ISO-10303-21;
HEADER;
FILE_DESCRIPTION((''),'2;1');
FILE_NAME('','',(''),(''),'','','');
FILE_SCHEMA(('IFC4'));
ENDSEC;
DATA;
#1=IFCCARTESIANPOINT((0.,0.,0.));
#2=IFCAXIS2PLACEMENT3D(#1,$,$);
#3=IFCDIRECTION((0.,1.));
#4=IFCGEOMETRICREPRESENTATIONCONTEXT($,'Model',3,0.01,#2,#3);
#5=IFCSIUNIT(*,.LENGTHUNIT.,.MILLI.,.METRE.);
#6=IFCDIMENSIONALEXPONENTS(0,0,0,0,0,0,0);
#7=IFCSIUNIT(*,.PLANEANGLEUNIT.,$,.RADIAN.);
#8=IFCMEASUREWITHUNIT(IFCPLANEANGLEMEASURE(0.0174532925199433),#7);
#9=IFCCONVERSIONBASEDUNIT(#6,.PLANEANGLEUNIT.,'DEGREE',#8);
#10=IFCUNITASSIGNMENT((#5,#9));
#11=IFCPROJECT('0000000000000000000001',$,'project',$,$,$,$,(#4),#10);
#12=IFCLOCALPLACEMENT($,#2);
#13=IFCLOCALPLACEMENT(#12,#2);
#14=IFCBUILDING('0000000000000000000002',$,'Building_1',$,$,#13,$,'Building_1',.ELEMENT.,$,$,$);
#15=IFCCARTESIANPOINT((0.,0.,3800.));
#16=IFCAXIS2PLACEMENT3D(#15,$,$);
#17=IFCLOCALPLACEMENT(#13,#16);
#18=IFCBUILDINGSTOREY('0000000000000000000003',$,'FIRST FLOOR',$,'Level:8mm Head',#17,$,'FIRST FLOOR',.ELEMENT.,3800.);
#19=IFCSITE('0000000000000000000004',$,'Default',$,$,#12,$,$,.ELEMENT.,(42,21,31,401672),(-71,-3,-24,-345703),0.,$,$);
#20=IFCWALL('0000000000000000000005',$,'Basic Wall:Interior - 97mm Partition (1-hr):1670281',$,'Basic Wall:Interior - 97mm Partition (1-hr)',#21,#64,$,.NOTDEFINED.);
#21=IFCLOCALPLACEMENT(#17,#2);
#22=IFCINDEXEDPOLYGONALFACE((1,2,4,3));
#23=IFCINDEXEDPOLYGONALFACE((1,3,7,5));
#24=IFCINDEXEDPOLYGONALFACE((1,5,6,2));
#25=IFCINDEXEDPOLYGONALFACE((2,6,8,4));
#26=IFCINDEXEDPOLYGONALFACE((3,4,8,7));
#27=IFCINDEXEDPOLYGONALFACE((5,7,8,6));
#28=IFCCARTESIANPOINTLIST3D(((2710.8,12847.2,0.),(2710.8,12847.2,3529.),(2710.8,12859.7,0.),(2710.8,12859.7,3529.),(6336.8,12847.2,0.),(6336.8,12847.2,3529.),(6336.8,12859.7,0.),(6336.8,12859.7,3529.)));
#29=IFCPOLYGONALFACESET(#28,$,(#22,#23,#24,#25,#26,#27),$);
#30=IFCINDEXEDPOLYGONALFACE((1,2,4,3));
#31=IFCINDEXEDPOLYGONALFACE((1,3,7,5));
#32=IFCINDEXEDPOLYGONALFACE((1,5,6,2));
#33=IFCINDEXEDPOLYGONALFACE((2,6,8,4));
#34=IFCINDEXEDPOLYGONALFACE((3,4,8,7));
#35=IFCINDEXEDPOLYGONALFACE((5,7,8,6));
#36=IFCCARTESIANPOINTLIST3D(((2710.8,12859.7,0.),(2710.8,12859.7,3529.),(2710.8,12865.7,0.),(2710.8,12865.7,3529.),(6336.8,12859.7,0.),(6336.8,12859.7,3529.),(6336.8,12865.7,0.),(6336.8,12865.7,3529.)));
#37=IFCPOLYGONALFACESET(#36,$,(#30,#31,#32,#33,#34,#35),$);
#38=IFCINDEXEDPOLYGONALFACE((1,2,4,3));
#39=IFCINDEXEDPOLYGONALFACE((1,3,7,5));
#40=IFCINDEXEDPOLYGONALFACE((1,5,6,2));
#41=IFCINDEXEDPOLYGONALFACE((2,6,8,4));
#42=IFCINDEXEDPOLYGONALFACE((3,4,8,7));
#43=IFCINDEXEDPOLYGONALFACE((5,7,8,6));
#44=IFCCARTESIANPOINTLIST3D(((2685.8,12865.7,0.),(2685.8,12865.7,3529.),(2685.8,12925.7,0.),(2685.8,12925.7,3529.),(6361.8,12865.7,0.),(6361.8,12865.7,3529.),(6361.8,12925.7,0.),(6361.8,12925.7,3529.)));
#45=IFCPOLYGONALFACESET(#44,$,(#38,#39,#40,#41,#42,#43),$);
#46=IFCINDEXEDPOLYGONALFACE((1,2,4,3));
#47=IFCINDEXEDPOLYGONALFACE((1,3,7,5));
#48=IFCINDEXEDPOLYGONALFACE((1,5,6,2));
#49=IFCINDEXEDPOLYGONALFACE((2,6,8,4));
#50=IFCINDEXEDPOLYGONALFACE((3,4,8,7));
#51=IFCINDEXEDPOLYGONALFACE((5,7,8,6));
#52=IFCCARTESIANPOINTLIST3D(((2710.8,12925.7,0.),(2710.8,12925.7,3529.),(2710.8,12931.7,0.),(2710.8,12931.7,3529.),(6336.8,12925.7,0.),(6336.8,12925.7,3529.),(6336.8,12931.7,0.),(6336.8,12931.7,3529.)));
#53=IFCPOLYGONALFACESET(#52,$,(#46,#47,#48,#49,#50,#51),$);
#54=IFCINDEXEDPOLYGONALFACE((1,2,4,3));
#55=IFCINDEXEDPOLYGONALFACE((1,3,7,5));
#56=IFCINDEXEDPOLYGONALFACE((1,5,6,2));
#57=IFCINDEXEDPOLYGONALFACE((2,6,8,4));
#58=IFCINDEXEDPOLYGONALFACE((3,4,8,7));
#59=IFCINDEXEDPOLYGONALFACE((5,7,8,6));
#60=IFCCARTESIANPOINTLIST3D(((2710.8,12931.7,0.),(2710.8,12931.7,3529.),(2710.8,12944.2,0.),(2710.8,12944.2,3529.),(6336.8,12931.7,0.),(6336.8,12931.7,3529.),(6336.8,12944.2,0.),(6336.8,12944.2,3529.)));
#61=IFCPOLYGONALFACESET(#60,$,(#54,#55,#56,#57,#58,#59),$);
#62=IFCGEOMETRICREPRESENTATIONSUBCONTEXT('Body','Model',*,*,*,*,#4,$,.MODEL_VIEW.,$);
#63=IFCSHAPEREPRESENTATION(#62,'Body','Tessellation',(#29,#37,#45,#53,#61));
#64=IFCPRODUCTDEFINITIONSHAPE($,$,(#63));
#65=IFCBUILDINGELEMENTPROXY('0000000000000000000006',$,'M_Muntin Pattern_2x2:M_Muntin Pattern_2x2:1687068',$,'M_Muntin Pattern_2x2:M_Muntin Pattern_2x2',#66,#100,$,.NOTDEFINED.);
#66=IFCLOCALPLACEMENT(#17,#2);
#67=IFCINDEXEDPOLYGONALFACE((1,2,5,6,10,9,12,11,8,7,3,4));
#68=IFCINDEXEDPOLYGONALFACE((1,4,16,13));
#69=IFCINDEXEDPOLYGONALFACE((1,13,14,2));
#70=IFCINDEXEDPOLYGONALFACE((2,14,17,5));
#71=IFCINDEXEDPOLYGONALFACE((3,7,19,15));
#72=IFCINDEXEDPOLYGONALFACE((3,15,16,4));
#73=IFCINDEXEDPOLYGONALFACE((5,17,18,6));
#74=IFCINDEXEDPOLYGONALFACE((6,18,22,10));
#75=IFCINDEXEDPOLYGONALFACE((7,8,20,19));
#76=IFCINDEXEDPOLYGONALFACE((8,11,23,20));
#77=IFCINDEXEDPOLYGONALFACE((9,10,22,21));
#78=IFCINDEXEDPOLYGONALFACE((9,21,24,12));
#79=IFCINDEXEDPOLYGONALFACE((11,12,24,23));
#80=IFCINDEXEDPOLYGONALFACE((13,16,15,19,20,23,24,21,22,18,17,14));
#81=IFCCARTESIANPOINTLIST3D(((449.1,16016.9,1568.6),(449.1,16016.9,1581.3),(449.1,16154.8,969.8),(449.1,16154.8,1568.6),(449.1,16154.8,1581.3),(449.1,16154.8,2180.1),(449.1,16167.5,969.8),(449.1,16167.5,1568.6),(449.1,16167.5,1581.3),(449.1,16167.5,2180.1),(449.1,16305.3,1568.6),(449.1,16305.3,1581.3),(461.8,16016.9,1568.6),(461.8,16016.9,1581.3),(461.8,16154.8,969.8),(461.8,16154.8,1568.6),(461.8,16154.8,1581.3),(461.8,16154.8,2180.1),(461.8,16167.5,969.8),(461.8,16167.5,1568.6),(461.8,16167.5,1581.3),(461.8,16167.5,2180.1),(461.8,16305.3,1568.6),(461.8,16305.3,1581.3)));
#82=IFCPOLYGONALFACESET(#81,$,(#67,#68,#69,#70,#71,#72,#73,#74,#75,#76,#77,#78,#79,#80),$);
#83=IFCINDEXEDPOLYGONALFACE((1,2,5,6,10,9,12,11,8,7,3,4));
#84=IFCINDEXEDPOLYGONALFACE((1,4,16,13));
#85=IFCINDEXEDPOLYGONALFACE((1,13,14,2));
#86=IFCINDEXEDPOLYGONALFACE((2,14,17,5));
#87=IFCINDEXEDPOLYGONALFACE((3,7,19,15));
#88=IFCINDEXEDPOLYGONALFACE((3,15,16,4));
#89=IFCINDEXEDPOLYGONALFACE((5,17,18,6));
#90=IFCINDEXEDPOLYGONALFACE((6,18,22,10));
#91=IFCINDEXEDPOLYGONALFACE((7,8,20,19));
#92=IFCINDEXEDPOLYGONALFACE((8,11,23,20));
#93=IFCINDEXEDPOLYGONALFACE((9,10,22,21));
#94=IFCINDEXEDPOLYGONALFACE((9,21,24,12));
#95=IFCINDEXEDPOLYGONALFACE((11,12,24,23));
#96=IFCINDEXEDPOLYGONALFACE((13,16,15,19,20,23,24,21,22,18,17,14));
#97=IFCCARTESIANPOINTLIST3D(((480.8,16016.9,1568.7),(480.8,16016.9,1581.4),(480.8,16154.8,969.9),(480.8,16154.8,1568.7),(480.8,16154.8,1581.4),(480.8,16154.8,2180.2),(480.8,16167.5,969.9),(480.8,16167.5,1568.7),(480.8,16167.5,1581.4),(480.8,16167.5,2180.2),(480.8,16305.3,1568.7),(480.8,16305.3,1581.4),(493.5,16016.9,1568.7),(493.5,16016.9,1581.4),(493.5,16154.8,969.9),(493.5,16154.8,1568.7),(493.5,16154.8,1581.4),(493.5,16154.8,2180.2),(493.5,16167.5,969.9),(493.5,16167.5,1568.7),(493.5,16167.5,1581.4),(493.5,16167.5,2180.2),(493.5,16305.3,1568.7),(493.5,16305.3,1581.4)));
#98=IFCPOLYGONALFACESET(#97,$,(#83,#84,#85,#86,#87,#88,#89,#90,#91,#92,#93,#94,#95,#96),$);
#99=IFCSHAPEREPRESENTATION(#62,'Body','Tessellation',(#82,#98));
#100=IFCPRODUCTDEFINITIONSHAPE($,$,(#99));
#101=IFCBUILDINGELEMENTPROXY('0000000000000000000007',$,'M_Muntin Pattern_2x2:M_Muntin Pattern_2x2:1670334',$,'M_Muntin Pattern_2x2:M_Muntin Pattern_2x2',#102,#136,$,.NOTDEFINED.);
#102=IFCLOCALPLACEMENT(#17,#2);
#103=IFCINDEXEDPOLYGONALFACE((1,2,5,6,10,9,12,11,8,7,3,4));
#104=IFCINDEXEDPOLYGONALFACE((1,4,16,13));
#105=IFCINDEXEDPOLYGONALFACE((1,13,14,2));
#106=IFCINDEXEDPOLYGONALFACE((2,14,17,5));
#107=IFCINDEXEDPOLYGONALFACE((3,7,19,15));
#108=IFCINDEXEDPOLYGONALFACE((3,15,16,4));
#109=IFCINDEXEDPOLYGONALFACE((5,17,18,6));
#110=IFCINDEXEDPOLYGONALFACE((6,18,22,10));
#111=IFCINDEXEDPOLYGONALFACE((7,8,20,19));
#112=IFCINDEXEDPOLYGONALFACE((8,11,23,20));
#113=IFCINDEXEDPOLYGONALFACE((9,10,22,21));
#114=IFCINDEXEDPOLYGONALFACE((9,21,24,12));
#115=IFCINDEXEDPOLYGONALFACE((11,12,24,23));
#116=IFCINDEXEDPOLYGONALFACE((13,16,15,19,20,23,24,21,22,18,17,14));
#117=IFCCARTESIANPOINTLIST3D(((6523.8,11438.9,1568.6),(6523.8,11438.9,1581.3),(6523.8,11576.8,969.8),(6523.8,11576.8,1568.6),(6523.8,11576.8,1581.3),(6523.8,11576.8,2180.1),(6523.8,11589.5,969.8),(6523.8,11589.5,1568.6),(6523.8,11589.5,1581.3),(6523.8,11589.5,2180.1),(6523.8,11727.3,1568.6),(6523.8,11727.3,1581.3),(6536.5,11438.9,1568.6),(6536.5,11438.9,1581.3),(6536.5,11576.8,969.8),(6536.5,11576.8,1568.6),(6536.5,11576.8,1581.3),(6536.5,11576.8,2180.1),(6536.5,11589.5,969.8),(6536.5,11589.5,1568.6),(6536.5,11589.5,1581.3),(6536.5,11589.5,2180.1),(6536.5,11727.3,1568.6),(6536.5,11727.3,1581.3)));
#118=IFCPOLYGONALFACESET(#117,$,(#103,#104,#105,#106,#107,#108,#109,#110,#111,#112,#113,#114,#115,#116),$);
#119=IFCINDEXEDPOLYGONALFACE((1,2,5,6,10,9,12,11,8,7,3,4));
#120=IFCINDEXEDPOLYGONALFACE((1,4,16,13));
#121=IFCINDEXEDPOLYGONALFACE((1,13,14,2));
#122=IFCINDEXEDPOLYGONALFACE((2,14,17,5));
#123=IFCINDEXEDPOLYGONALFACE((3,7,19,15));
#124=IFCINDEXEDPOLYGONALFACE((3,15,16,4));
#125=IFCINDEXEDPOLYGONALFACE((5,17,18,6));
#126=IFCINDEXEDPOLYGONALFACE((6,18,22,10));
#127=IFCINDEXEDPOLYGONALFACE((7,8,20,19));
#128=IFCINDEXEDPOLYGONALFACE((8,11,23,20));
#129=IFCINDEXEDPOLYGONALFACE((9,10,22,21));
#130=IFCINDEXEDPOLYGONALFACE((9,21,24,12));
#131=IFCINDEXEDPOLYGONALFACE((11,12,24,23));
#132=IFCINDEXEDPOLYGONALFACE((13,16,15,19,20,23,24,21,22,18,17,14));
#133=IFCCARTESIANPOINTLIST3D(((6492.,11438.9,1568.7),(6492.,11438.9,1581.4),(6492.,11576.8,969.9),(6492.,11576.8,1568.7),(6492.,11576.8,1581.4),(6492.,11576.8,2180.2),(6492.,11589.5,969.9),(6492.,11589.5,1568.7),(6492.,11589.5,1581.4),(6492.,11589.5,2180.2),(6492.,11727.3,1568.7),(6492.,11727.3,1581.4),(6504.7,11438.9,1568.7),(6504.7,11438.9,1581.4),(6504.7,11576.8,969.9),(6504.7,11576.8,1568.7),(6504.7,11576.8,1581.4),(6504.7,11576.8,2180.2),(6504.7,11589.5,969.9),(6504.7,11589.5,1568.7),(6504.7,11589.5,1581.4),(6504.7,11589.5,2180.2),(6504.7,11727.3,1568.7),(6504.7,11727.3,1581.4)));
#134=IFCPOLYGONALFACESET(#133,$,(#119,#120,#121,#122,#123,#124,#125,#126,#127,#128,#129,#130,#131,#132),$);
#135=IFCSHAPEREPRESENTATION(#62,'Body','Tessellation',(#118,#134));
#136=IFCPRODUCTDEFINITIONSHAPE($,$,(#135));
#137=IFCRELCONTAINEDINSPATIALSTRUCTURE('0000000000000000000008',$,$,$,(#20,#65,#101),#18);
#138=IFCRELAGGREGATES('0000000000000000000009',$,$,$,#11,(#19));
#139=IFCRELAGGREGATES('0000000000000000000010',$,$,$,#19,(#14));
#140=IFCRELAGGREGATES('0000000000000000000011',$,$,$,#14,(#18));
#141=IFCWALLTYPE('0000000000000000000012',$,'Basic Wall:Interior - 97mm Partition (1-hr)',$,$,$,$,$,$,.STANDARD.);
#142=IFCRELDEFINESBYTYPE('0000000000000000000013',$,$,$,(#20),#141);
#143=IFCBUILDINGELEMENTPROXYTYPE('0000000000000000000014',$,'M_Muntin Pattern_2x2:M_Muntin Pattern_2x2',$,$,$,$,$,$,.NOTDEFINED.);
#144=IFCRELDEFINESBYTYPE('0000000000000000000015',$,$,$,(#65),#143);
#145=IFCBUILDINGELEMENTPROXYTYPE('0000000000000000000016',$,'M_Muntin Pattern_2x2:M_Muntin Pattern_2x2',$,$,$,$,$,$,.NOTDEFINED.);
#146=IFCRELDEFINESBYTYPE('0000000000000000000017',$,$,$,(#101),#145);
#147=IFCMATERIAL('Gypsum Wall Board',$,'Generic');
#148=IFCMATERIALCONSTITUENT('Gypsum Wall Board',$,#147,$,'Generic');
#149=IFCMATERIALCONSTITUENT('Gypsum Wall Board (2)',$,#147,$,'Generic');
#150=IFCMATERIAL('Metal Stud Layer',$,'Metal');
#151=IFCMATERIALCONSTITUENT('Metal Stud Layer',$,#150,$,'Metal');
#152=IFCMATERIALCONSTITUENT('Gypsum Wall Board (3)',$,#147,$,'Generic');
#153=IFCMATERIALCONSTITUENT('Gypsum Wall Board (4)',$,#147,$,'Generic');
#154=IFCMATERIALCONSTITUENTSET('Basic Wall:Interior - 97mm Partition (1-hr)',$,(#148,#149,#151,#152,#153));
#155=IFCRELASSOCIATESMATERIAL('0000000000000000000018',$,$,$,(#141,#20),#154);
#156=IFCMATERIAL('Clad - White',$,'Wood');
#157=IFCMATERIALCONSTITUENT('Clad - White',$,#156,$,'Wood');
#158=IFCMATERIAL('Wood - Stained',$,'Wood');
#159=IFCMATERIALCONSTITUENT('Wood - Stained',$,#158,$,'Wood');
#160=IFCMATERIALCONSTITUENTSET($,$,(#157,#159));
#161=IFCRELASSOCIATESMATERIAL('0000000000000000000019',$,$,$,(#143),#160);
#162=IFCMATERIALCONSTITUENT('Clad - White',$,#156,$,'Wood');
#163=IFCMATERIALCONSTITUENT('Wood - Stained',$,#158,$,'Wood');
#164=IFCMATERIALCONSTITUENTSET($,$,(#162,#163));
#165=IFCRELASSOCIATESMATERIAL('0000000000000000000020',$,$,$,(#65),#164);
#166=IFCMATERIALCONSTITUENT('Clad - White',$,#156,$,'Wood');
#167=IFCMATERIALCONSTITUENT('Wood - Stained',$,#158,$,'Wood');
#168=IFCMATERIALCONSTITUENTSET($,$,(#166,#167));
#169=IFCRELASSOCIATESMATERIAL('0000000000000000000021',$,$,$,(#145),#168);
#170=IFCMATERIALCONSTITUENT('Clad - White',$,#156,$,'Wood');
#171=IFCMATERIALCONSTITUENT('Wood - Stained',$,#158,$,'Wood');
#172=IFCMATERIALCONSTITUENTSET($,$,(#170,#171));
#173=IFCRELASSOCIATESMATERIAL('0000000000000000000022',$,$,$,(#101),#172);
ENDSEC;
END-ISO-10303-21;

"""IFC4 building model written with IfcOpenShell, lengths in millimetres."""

from ifc_helpers import new_model, entity, si_unit, converted_unit, direction, frame, origin, place, context, subcontext, project, spatial, indexed_curve, outline, extrude, source, transform, mapped, material, constituent, constituent_set, type_object, type_shapes, element, save


model = new_model("IFC4")

# Units and contexts
model_context = context("Model", 3, precision=0.01, world=origin(), true_north=direction((0.0, 1.0)))
body_context = subcontext(model_context, "Body", "Model", "MODEL_VIEW")
ifc_project = project(units=[si_unit("LENGTHUNIT", "METRE", prefix="MILLI"), converted_unit("PLANEANGLEUNIT", "DEGREE", entity("IfcPlaneAngleMeasure", 0.0174532925199433), si_unit("PLANEANGLEUNIT", "RADIAN"), dimensions=[0, 0, 0, 0, 0, 0, 0])], contexts=[model_context])

# Site, building, storey
site_placement = place(None, origin())
site = spatial("IfcSite", under=ifc_project, at=site_placement, Name="Default", CompositionType="ELEMENT", RefLatitude=(42, 21, 31, 401672), RefLongitude=(-71, -3, -24, -345703), RefElevation=0.0)
building_placement = place(site_placement, origin())
building = spatial("IfcBuilding", under=site, at=building_placement, Name="Building_1", LongName="Building_1", CompositionType="ELEMENT")
storey_placement = place(building_placement, frame((0.0, 0.0, 3800.0)))
storey = spatial("IfcBuildingStorey", under=building, at=storey_placement, Name="FIRST FLOOR", ObjectType="Level:8mm Head", LongName="FIRST FLOOR", CompositionType="ELEMENT", Elevation=3800.0)

# Shared definitions
ifc_material_1 = material(Name="Wood - Stained", Category="Wood")

# Wall
ifc_material_2 = material(Name="Gypsum Wall Board", Category="Generic")
ifc_constituent_1 = constituent(ifc_material_2, Name="Gypsum Wall Board", Category="Generic")
ifc_constituent_2 = constituent(ifc_material_2, Name="Gypsum Wall Board (2)", Category="Generic")
ifc_material_3 = material(Name="Metal Stud Layer", Category="Metal")
ifc_constituent_3 = constituent(ifc_material_3, Name="Metal Stud Layer", Category="Metal")
ifc_constituent_4 = constituent(ifc_material_2, Name="Gypsum Wall Board (3)", Category="Generic")
ifc_constituent_5 = constituent(ifc_material_2, Name="Gypsum Wall Board (4)", Category="Generic")
ifc_constituent_set_1 = constituent_set(constituents=[ifc_constituent_1, ifc_constituent_2, ifc_constituent_3, ifc_constituent_4, ifc_constituent_5], Name="Basic Wall:Interior - 97mm Partition (1-hr)")
wall_type_1 = type_object("IfcWallType", Name="Basic Wall:Interior - 97mm Partition (1-hr)", PredefinedType="STANDARD", material=ifc_constituent_set_1)
wall_1_placement = place(storey_placement, frame((6336.8, 12895.7, 0.0), z_axis=(0.0, 0.0, 1.0), x_axis=(-1.0, 0.0, 0.0)))
element("IfcWall", 1, at=wall_1_placement, inside=storey, type_object=wall_type_1, material=ifc_constituent_set_1, Name="Basic Wall:Interior - 97mm Partition (1-hr):1670281", ObjectType="Basic Wall:Interior - 97mm Partition (1-hr)", PredefinedType="NOTDEFINED", context=body_context, shape_type="SweptSolid", body=[
    extrude(outline(indexed_curve([(-6.2, -1764.5), (6.3, -1764.5), (6.3, 1764.5), (-6.2, 1764.5), (-6.2, -1764.5)], self_intersect=False)), frame((3626.0, 42.2, 1764.5), z_axis=(-1.0, 0.0, 0.0), x_axis=(0.0, -1.0, 0.0)), (0.0, 0.0, 1.0), 3626.0),
    extrude(outline(indexed_curve([(-1764.5, -3.0), (1764.5, -3.0), (1764.5, 3.0), (-1764.5, 3.0), (-1764.5, -3.0)], self_intersect=False)), frame((3626.0, 33.0, 1764.5), z_axis=(-1.0, 0.0, 0.0), x_axis=(0.0, 0.0, 1.0)), (0.0, 0.0, 1.0), 3626.0),
    extrude(outline(indexed_curve([(-1764.5, -30.0), (1764.5, -30.0), (1764.5, 30.0), (-1764.5, 30.0), (-1764.5, -30.0)], self_intersect=False)), frame((3651.0, 0.0, 1764.5), z_axis=(-1.0, 0.0, 0.0), x_axis=(0.0, 0.0, 1.0)), (0.0, 0.0, 1.0), 3676.0),
    extrude(outline(indexed_curve([(-1764.5, -3.0), (1764.5, -3.0), (1764.5, 3.0), (-1764.5, 3.0), (-1764.5, -3.0)], self_intersect=False)), frame((3626.0, -33.0, 1764.5), z_axis=(-1.0, 0.0, 0.0), x_axis=(0.0, 0.0, 1.0)), (0.0, 0.0, 1.0), 3626.0),
    extrude(outline(indexed_curve([(-6.2, -1764.5), (6.3, -1764.5), (6.3, 1764.5), (-6.2, 1764.5), (-6.2, -1764.5)], self_intersect=False)), frame((3626.0, -42.3, 1764.5), z_axis=(-1.0, 0.0, 0.0), x_axis=(0.0, 1.0, 0.0)), (0.0, 0.0, 1.0), 3626.0),
])

# Building element proxies
ifc_material_4 = material(Name="Clad - White", Category="Wood")
ifc_constituent_6 = constituent(ifc_material_4, Name="Clad - White", Category="Wood")
ifc_constituent_7 = constituent(ifc_material_1, Name="Wood - Stained", Category="Wood")
ifc_constituent_set_2 = constituent_set(constituents=[ifc_constituent_6, ifc_constituent_7])
ifc_constituent_8 = constituent(ifc_material_4, Name="Clad - White", Category="Wood")
ifc_constituent_9 = constituent(ifc_material_1, Name="Wood - Stained", Category="Wood")
ifc_constituent_set_3 = constituent_set(constituents=[ifc_constituent_8, ifc_constituent_9])
building_element_proxy_type_1 = type_object("IfcBuildingElementProxyType", Name="M_Muntin Pattern_2x2:M_Muntin Pattern_2x2", PredefinedType="NOTDEFINED", material=ifc_constituent_set_3)
shared_shape_1 = source(origin(), body_context, "Body", "SweptSolid", [
    extrude(outline(indexed_curve([(6.4, -6.4), (605.1, -6.4), (605.1, 6.3), (6.4, 6.3), (6.4, 144.2), (-6.3, 144.2), (-6.3, 6.3), (-605.2, 6.3), (-605.2, -6.4), (-6.3, -6.4), (-6.3, -144.2), (6.4, -144.2), (6.4, -6.4)], self_intersect=False)), frame((0.0, -22.2, 605.1), z_axis=(0.0, 1.0, 0.0), x_axis=(0.0, 0.0, 1.0)), (0.0, 0.0, 1.0), 12.7),
    extrude(outline(indexed_curve([(6.4, -6.4), (605.2, -6.4), (605.2, 6.3), (6.4, 6.3), (6.4, 144.2), (-6.3, 144.2), (-6.3, 6.3), (-605.2, 6.3), (-605.2, -6.4), (-6.3, -6.4), (-6.3, -144.2), (6.4, -144.2), (6.4, -6.4)], self_intersect=False)), frame((0.0, 9.5, 605.2), z_axis=(0.0, 1.0, 0.0), x_axis=(0.0, 0.0, 1.0)), (0.0, 0.0, 1.0), 12.7),
])
type_shapes(building_element_proxy_type_1, [shared_shape_1])
proxy_1_placement = place(storey_placement, frame((471.3, 16161.1, 969.9), z_axis=(0.0, 0.0, 1.0), x_axis=(0.0, -1.0, 0.0)))
element("IfcBuildingElementProxy", 2, at=proxy_1_placement, inside=storey, type_object=building_element_proxy_type_1, material=ifc_constituent_set_2, Name="M_Muntin Pattern_2x2:M_Muntin Pattern_2x2:1687068", ObjectType="M_Muntin Pattern_2x2:M_Muntin Pattern_2x2", PredefinedType="NOTDEFINED", context=body_context, shape_type="MappedRepresentation", body=[
    mapped(shared_shape_1, transform((0.0, 0.0, 0.0), scale=1.0)),
])
ifc_constituent_10 = constituent(ifc_material_4, Name="Clad - White", Category="Wood")
ifc_constituent_11 = constituent(ifc_material_1, Name="Wood - Stained", Category="Wood")
ifc_constituent_set_4 = constituent_set(constituents=[ifc_constituent_10, ifc_constituent_11])
ifc_constituent_12 = constituent(ifc_material_4, Name="Clad - White", Category="Wood")
ifc_constituent_13 = constituent(ifc_material_1, Name="Wood - Stained", Category="Wood")
ifc_constituent_set_5 = constituent_set(constituents=[ifc_constituent_12, ifc_constituent_13])
building_element_proxy_type_2 = type_object("IfcBuildingElementProxyType", Name="M_Muntin Pattern_2x2:M_Muntin Pattern_2x2", PredefinedType="NOTDEFINED", material=ifc_constituent_set_5)
shared_shape_2 = source(origin(), body_context, "Body", "SweptSolid", [
    extrude(outline(indexed_curve([(6.4, -6.4), (605.1, -6.4), (605.1, 6.3), (6.4, 6.3), (6.4, 144.2), (-6.3, 144.2), (-6.3, 6.3), (-605.2, 6.3), (-605.2, -6.4), (-6.3, -6.4), (-6.3, -144.2), (6.4, -144.2), (6.4, -6.4)], self_intersect=False)), frame((0.0, 9.5, 605.1), z_axis=(0.0, 1.0, 0.0), x_axis=(0.0, 0.0, 1.0)), (0.0, 0.0, 1.0), 12.7),
    extrude(outline(indexed_curve([(6.4, -6.4), (605.2, -6.4), (605.2, 6.3), (6.4, 6.3), (6.4, 144.2), (-6.3, 144.2), (-6.3, 6.3), (-605.2, 6.3), (-605.2, -6.4), (-6.3, -6.4), (-6.3, -144.2), (6.4, -144.2), (6.4, -6.4)], self_intersect=False)), frame((0.0, -22.2, 605.2), z_axis=(0.0, 1.0, 0.0), x_axis=(0.0, 0.0, 1.0)), (0.0, 0.0, 1.0), 12.7),
])
type_shapes(building_element_proxy_type_2, [shared_shape_2])
proxy_2_placement = place(storey_placement, frame((6514.3, 11583.1, 969.9), z_axis=(0.0, 0.0, 1.0), x_axis=(0.0, -1.0, 0.0)))
element("IfcBuildingElementProxy", 3, at=proxy_2_placement, inside=storey, type_object=building_element_proxy_type_2, material=ifc_constituent_set_4, Name="M_Muntin Pattern_2x2:M_Muntin Pattern_2x2:1670334", ObjectType="M_Muntin Pattern_2x2:M_Muntin Pattern_2x2", PredefinedType="NOTDEFINED", context=body_context, shape_type="MappedRepresentation", body=[
    mapped(shared_shape_2, transform((0.0, 0.0, 0.0), scale=1.0)),
])

save(model, "model.ifc")
